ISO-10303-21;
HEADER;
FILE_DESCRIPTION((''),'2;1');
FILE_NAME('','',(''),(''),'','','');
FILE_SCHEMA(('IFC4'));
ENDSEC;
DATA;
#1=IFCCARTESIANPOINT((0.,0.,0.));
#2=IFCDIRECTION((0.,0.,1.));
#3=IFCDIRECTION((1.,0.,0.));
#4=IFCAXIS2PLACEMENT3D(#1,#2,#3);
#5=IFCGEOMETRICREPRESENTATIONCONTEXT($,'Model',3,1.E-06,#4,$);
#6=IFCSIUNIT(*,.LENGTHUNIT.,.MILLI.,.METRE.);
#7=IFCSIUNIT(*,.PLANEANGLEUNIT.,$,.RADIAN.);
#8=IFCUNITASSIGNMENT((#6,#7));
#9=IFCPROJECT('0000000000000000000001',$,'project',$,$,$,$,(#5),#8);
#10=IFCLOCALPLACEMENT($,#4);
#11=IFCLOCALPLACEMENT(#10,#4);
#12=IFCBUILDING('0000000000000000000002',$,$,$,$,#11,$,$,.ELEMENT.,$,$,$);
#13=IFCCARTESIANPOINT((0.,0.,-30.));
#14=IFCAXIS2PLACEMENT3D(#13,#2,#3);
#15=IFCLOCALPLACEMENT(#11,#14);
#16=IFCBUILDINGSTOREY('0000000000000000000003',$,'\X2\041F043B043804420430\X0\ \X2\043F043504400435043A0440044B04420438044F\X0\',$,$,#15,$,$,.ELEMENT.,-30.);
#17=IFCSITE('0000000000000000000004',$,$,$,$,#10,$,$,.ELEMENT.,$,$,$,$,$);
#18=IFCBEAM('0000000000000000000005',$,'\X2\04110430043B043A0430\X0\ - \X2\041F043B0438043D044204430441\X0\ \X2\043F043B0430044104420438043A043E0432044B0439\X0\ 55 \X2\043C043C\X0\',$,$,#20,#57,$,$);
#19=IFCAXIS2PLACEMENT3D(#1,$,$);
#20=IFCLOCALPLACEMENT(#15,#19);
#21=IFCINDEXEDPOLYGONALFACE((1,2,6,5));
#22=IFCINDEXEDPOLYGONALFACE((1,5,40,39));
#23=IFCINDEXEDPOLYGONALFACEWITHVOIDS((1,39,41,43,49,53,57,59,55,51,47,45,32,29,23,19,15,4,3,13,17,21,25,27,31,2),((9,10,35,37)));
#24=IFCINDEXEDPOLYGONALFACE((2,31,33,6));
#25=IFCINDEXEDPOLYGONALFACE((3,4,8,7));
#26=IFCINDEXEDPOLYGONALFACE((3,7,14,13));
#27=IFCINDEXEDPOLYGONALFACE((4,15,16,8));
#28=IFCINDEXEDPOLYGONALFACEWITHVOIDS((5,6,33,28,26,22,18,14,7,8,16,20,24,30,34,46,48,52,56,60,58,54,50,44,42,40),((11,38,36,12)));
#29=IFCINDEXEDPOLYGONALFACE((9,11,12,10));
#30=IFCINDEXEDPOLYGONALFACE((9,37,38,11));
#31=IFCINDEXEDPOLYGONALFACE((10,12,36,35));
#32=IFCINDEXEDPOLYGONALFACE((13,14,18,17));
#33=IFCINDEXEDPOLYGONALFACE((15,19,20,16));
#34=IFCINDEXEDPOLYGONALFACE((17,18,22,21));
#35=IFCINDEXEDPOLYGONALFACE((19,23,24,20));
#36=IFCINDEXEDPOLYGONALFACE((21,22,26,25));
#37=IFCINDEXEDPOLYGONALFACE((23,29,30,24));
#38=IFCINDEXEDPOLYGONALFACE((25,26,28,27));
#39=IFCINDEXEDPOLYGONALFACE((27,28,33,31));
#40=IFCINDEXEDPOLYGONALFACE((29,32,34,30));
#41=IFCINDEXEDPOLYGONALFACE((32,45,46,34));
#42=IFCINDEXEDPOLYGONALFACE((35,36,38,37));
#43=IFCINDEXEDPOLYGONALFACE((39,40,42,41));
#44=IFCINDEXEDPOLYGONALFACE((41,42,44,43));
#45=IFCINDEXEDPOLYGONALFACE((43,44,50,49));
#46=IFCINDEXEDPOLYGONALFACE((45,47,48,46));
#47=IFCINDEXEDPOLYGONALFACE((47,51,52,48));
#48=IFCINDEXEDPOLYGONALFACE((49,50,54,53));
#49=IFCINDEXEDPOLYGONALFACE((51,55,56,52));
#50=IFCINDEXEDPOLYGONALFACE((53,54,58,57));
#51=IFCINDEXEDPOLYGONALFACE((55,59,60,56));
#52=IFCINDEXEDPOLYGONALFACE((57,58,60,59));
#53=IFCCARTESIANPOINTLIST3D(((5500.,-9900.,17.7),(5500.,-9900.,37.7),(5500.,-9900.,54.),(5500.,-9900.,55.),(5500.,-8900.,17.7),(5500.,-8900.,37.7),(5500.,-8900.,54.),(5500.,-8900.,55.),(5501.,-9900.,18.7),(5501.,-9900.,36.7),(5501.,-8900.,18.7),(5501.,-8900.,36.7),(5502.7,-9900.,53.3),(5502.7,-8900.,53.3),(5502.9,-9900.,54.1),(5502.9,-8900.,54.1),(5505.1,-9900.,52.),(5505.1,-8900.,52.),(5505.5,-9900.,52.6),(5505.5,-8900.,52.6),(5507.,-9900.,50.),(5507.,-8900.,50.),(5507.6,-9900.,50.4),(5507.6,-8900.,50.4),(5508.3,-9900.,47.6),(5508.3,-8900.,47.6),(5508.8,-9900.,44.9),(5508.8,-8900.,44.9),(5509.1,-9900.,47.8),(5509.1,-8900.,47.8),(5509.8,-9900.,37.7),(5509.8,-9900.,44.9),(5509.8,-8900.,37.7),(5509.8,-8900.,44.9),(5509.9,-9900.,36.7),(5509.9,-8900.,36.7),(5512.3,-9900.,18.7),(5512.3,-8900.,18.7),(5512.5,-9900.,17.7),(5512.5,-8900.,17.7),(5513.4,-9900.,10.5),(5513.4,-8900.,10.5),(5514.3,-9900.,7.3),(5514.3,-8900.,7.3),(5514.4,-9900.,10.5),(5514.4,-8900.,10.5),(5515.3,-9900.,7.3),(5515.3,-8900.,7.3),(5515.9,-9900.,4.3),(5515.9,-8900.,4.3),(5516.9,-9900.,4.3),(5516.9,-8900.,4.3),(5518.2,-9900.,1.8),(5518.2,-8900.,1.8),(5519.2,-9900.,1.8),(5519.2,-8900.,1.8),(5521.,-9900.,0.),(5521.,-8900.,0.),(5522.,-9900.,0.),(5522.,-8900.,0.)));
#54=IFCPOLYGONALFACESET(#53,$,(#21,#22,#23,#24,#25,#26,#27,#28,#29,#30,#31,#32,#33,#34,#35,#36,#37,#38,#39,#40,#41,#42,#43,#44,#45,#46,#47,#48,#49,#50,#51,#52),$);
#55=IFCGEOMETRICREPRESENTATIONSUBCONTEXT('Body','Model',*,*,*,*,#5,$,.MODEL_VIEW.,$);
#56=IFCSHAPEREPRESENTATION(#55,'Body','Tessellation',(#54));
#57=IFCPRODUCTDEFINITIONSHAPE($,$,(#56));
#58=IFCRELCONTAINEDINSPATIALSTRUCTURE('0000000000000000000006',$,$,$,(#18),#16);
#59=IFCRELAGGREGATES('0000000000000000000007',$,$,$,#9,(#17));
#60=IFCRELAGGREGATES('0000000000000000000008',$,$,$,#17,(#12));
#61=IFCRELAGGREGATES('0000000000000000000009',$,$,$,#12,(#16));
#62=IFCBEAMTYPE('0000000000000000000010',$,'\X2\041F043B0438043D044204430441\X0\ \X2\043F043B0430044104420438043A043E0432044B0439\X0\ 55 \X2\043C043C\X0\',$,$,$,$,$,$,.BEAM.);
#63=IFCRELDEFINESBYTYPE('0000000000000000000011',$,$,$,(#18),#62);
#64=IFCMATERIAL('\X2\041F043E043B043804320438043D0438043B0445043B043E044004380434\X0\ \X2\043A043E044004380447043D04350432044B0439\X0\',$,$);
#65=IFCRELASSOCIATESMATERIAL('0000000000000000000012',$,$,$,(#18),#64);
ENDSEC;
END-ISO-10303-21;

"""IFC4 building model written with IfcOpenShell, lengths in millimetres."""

from ifc_helpers import new_model, si_unit, frame, origin_with_axes, place, context, subcontext, project, spatial, line, arc, indexed_curve, outline, extrude, source, transform, mapped, material, type_object, element, save


model = new_model("IFC4")

# Units and contexts
model_context = context("Model", 3, precision=1e-06, world=origin_with_axes())
body_context = subcontext(model_context, "Body", "Model", "MODEL_VIEW")
ifc_project = project(units=[si_unit("LENGTHUNIT", "METRE", prefix="MILLI"), si_unit("PLANEANGLEUNIT", "RADIAN")], contexts=[model_context])

# Site, building, storey
site_placement = place(None, origin_with_axes())
site = spatial("IfcSite", under=ifc_project, at=site_placement, CompositionType="ELEMENT")
building_placement = place(site_placement, origin_with_axes())
building = spatial("IfcBuilding", under=site, at=building_placement, CompositionType="ELEMENT")
storey_placement = place(building_placement, frame((0.0, 0.0, -30.0), z_axis=(0.0, 0.0, 1.0), x_axis=(1.0, 0.0, 0.0)))
storey = spatial("IfcBuildingStorey", under=building, at=storey_placement, Name="Плита перекрытия", CompositionType="ELEMENT", Elevation=-30.0)

# Beam
ifc_material_1 = material(Name="Поливинилхлорид коричневый")
beam_type_1 = type_object("IfcBeamType", Name="Плинтус пластиковый 55 мм", PredefinedType="BEAM")
shared_shape_1 = source(origin_with_axes(), body_context, "Body", "SweptSolid", [
    extrude(outline(indexed_curve([(0.0, 55.0), (-6.6, 51.5), (-9.8, 44.9), (-14.4, 10.5), (-16.9, 4.3), (-22.0, 0.0), (-21.0, 0.0), (-15.9, 4.3), (-13.4, 10.5), (-12.5, 17.7), (0.0, 17.7), (0.0, 37.7), (-9.8, 37.7), (-8.8, 44.9), (-6.1, 51.0), (0.0, 54.0)], segments=[arc(1, 2, 3), line(3, 4), arc(4, 5, 6), line(6, 7), arc(7, 8, 9), line(9, 10), line(10, 11), line(11, 12), line(12, 13), line(13, 14), arc(14, 15, 16), line(16, 1)]), holes=[indexed_curve([(-9.9, 36.7), (-1.0, 36.7), (-1.0, 18.7), (-12.3, 18.7)], segments=[line(1, 2), line(2, 3), line(3, 4), line(4, 1)])]), origin_with_axes(), (0.0, 0.0, -1.0), 1000.0),
])
beam_1_placement = place(storey_placement, frame((5500.0, -8900.0, 0.0), z_axis=(0.0, 1.0, 0.0), x_axis=(-1.0, 0.0, 0.0)))
element("IfcBeam", 1, at=beam_1_placement, inside=storey, type_object=beam_type_1, material=ifc_material_1, Name="Балка - Плинтус пластиковый 55 мм", context=body_context, shape_type="MappedRepresentation", body=[
    mapped(shared_shape_1, transform((0.0, 0.0, 0.0), x_axis=(1.0, 0.0, 0.0), y_axis=(0.0, 1.0, 0.0), z_axis=(0.0, 0.0, 1.0), scale=1.0)),
])

save(model, "model.ifc")
